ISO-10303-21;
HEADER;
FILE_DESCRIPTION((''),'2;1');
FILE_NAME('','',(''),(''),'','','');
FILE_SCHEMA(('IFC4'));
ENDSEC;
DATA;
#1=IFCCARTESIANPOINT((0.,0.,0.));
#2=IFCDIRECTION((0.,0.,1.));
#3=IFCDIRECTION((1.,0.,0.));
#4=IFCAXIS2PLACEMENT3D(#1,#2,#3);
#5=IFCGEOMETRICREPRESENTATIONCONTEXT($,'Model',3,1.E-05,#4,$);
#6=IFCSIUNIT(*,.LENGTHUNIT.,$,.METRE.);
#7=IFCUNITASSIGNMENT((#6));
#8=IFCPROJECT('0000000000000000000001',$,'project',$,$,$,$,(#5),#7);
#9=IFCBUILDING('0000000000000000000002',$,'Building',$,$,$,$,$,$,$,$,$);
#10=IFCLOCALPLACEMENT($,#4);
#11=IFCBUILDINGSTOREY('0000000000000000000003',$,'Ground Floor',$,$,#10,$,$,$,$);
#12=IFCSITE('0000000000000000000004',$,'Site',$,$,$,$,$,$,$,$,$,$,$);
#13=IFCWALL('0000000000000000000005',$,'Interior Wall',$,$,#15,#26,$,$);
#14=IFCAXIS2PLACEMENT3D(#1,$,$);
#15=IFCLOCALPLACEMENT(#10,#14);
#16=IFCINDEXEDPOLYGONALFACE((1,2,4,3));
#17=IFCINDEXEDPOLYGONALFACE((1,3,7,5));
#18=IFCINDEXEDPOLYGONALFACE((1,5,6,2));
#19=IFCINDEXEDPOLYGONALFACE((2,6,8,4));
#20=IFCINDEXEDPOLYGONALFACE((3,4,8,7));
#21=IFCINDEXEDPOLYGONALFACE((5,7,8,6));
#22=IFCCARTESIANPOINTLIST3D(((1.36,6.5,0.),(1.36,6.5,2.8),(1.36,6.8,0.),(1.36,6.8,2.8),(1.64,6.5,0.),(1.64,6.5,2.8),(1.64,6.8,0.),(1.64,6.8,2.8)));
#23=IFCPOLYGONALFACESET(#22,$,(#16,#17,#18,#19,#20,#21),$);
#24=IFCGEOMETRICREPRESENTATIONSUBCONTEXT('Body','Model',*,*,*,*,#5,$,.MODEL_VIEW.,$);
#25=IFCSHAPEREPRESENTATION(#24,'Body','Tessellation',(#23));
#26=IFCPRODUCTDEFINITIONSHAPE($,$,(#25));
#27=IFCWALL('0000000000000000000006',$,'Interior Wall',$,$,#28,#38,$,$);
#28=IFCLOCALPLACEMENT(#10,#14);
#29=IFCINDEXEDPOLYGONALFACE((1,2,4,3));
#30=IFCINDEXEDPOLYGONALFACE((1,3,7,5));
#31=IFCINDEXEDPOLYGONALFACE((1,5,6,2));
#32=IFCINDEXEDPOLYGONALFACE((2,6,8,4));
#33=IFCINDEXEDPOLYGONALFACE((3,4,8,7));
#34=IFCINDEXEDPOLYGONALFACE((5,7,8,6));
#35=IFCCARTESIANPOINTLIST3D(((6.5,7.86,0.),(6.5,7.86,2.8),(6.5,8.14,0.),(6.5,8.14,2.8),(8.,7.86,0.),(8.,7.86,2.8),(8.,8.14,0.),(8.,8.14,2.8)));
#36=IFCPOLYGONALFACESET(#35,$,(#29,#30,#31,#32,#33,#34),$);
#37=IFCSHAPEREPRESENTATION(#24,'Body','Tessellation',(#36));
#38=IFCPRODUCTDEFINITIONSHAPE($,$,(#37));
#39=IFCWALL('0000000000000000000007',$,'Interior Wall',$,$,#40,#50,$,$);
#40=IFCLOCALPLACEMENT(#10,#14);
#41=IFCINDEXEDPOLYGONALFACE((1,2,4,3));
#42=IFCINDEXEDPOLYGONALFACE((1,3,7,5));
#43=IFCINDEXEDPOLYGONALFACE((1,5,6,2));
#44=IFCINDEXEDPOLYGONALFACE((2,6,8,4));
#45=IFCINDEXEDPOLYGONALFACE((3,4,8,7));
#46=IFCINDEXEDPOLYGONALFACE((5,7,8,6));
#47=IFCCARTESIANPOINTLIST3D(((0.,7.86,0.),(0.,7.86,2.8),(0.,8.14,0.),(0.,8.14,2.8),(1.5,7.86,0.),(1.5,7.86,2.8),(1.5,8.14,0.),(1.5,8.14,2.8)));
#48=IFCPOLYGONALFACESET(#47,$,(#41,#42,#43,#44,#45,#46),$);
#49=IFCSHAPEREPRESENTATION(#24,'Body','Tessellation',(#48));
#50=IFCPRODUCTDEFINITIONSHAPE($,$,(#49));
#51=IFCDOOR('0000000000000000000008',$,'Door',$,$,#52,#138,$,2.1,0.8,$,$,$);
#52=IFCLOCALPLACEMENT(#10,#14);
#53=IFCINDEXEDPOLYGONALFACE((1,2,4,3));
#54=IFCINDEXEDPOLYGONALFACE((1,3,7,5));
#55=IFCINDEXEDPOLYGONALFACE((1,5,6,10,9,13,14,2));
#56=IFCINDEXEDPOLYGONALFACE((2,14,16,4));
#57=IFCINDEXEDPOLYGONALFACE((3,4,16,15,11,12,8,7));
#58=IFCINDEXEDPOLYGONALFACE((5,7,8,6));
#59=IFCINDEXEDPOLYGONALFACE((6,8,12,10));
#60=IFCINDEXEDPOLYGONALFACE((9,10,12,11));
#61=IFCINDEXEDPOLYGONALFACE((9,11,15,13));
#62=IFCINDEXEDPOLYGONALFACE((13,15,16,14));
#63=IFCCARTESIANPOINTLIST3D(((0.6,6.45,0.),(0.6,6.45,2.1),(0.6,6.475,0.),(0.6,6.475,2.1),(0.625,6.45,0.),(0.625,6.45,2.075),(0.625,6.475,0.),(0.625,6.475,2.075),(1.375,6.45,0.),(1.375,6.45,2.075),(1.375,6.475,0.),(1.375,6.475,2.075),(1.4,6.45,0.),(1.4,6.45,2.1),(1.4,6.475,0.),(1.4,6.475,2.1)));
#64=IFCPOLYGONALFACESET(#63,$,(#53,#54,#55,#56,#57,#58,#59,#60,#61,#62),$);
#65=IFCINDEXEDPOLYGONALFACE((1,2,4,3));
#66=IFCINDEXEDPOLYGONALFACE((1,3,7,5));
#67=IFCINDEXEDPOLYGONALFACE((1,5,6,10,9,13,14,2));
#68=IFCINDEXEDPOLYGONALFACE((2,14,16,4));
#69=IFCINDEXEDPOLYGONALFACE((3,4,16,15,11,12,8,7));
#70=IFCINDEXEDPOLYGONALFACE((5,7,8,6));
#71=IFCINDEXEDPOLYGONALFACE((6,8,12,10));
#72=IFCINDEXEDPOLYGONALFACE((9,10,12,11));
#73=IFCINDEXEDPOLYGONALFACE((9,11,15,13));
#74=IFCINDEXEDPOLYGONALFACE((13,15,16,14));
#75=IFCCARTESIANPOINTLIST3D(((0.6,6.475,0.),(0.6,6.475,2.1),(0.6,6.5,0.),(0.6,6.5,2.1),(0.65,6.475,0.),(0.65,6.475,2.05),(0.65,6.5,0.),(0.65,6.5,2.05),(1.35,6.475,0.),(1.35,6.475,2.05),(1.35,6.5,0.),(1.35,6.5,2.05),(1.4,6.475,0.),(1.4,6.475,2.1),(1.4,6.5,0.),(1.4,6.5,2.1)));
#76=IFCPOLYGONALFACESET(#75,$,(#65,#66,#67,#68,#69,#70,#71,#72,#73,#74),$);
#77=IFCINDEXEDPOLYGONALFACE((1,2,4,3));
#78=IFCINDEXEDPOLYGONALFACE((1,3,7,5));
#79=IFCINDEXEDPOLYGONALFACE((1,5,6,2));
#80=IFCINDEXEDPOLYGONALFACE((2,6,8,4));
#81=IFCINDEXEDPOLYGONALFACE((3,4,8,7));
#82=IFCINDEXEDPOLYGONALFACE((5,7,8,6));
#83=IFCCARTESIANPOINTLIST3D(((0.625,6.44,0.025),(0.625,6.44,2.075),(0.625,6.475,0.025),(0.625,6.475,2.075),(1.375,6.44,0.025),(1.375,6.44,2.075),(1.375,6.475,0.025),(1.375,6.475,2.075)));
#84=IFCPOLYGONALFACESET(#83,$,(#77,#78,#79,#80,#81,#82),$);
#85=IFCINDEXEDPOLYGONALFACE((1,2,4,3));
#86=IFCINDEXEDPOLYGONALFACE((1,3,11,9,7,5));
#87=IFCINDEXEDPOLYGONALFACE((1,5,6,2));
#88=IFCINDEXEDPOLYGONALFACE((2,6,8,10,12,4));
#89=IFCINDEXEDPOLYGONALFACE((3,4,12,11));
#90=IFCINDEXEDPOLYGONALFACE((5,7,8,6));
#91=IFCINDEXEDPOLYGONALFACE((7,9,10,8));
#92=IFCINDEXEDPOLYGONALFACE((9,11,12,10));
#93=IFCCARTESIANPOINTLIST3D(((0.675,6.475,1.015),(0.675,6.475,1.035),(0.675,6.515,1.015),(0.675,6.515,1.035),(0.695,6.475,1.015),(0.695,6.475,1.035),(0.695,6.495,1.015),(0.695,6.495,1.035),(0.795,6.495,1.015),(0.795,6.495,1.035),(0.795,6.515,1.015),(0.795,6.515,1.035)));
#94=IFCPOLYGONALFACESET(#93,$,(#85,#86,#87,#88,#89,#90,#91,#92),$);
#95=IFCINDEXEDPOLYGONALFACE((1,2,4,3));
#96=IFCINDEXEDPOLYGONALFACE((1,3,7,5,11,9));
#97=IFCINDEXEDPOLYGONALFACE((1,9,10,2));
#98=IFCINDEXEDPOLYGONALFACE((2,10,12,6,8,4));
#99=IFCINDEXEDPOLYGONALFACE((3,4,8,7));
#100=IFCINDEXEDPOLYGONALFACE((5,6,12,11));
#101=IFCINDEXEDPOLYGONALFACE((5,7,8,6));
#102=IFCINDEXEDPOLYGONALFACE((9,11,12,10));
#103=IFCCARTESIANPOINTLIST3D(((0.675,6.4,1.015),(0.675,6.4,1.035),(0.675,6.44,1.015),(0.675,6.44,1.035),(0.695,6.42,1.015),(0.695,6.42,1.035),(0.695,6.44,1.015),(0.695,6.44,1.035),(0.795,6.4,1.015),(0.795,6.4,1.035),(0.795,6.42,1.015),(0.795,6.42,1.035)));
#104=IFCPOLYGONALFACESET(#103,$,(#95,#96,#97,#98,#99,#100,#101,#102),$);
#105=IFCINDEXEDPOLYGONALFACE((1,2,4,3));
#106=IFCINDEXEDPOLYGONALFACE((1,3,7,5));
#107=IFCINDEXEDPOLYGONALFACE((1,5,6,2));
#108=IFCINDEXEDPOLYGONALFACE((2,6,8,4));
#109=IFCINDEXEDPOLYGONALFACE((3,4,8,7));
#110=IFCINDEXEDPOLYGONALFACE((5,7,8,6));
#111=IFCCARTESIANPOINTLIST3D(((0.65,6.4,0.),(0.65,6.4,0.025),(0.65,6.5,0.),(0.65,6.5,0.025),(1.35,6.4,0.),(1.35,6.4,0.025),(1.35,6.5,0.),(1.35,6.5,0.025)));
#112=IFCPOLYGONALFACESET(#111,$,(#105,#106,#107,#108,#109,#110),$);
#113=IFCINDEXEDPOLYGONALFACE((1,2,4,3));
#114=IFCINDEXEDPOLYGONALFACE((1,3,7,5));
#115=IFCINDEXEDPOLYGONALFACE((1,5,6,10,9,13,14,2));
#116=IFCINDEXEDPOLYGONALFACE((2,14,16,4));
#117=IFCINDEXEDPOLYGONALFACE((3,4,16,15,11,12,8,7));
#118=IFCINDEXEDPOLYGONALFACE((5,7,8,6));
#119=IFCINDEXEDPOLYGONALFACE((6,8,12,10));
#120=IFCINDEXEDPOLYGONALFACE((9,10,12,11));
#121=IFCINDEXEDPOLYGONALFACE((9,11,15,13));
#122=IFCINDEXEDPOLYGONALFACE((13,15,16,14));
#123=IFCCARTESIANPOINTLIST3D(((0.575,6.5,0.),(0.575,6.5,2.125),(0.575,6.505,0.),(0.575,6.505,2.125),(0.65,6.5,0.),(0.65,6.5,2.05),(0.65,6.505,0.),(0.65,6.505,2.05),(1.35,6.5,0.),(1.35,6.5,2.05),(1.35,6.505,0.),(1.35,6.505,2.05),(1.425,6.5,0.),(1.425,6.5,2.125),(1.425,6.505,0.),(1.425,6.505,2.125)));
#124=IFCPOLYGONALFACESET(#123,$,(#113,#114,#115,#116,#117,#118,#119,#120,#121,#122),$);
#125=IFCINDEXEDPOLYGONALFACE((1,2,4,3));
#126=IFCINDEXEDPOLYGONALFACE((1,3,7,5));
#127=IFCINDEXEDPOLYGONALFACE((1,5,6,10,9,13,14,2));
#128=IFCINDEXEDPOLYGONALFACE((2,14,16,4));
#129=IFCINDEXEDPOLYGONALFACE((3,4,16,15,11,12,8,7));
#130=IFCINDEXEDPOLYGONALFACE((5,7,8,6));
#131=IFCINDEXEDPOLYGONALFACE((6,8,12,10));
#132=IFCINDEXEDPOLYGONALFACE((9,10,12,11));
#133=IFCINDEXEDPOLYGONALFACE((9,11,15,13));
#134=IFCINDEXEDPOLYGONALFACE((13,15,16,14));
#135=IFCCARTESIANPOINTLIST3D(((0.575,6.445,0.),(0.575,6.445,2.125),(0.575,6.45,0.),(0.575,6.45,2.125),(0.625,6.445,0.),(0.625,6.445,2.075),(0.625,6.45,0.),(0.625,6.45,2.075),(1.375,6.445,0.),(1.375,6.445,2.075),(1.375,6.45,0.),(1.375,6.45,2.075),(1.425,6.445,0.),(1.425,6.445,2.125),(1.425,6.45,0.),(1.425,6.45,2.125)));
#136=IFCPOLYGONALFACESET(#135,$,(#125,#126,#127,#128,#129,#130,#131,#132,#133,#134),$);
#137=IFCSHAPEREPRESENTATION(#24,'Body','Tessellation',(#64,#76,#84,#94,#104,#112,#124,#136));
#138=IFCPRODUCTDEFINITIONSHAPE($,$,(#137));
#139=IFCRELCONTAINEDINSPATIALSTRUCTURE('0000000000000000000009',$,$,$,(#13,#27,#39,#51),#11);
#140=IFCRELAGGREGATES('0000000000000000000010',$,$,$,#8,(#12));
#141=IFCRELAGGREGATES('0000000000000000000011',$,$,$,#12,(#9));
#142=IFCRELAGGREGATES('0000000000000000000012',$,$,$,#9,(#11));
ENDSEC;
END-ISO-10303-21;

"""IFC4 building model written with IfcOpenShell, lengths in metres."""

from ifc_helpers import new_model, si_unit, frame, origin_with_axes, place, context, subcontext, project, spatial, line, indexed_curve, outline, extrude, element, save


model = new_model("IFC4")

# Units and contexts
model_context = context("Model", 3, precision=1e-05, world=origin_with_axes())
body_context = subcontext(model_context, "Body", "Model", "MODEL_VIEW")
ifc_project = project(units=[si_unit("LENGTHUNIT", "METRE")], contexts=[model_context])

# Site, building, storey
site = spatial("IfcSite", under=ifc_project, Name="Site")
building = spatial("IfcBuilding", under=site, Name="Building")
storey_placement = place(None, origin_with_axes())
storey = spatial("IfcBuildingStorey", under=building, at=storey_placement, Name="Ground Floor")

# Walls
for number, where, z_axis, x_axis, name in (
    (1, (1.5, 6.8, 0.0), (0.0, 0.0, 1.0), (0.0, -1.0, 0.0), "Interior Wall"),
):
    element("IfcWall", number, at=place(storey_placement, frame(where, z_axis=z_axis, x_axis=x_axis)), inside=storey, Name=name, context=body_context, shape_type="SweptSolid", body=[
        extrude(outline(indexed_curve([(0.0, 0.0), (0.0, 0.28), (0.3, 0.28), (0.3, 0.0), (0.0, 0.0)], self_intersect=False)), frame((0.0, -0.14, 0.0), z_axis=(0.0, 0.0, 1.0), x_axis=(1.0, 0.0, 0.0)), (0.0, 0.0, 1.0), 2.8),
    ])
for number, where, z_axis, x_axis, name in (
    (2, (8.0, 8.0, 0.0), (0.0, 0.0, 1.0), (-1.0, 0.0, 0.0), "Interior Wall"),
    (3, (1.5, 8.0, 0.0), (0.0, 0.0, 1.0), (-1.0, 0.0, 0.0), "Interior Wall"),
):
    element("IfcWall", number, at=place(storey_placement, frame(where, z_axis=z_axis, x_axis=x_axis)), inside=storey, Name=name, context=body_context, shape_type="SweptSolid", body=[
        extrude(outline(indexed_curve([(0.0, 0.0), (0.0, 0.28), (1.5, 0.28), (1.5, 0.0), (0.0, 0.0)], self_intersect=False)), frame((0.0, -0.14, 0.0), z_axis=(0.0, 0.0, 1.0), x_axis=(1.0, 0.0, 0.0)), (0.0, 0.0, 1.0), 2.8),
    ])

# Door
door_1_placement = place(storey_placement, frame((1.4, 6.5, 0.0), z_axis=(0.0, 0.0, 1.0), x_axis=(-1.0, 0.0, 0.0)))
element("IfcDoor", 4, at=door_1_placement, inside=storey, Name="Door", OverallHeight=2.1, OverallWidth=0.8, context=body_context, shape_type="SweptSolid", body=[
    extrude(outline(indexed_curve([(0.0, 0.0), (0.0, 2.1), (0.8, 2.1), (0.8, 0.0), (0.775, 0.0), (0.775, 2.075), (0.025, 2.075), (0.025, 0.0)], segments=[line(1, 2, 3, 4, 5, 6, 7, 8, 1)])), frame((0.0, 0.025, 0.0), z_axis=(0.0, -1.0, 0.0), x_axis=(1.0, 0.0, 0.0)), (0.0, 0.0, -1.0), 0.025),
    extrude(outline(indexed_curve([(0.0, 0.0), (0.0, 2.1), (0.8, 2.1), (0.8, 0.0), (0.75, 0.0), (0.75, 2.05), (0.05, 2.05), (0.05, 0.0)], segments=[line(1, 2, 3, 4, 5, 6, 7, 8, 1)])), frame((0.0, 0.0, 0.0), z_axis=(0.0, -1.0, 0.0), x_axis=(1.0, 0.0, 0.0)), (0.0, 0.0, -1.0), 0.025),
    extrude(outline(indexed_curve([(0.0, 0.0), (0.75, 0.0), (0.75, 0.035), (0.0, 0.035)], segments=[line(1, 2, 3, 4, 1)])), frame((0.025, 0.025, 0.025), z_axis=(0.0, 0.0, 1.0), x_axis=(1.0, 0.0, 0.0)), (0.0, 0.0, 1.0), 2.05),
    extrude(outline(indexed_curve([(0.0, 0.0), (0.0, -0.04), (-0.12, -0.04), (-0.12, -0.02), (-0.02, -0.02), (-0.02, 0.0)], segments=[line(1, 2, 3, 4, 5, 6, 1)])), frame((0.725, 0.025, 1.015), z_axis=(0.0, 0.0, 1.0), x_axis=(1.0, 0.0, 0.0)), (0.0, 0.0, 1.0), 0.02),
    extrude(outline(indexed_curve([(0.0, 0.0), (0.0, 0.04), (-0.12, 0.04), (-0.12, 0.02), (-0.02, 0.02), (-0.02, 0.0)], segments=[line(1, 2, 3, 4, 5, 6, 1)])), frame((0.725, 0.06, 1.015), z_axis=(0.0, 0.0, 1.0), x_axis=(1.0, 0.0, 0.0)), (0.0, 0.0, 1.0), 0.02),
    extrude(outline(indexed_curve([(0.0, 0.0), (0.7, 0.0), (0.7, 0.1), (0.0, 0.1)], segments=[line(1, 2, 3, 4, 1)])), frame((0.05, 0.0, 0.0), z_axis=(0.0, 0.0, 1.0), x_axis=(1.0, 0.0, 0.0)), (0.0, 0.0, 1.0), 0.025),
    extrude(outline(indexed_curve([(0.0, 0.0), (0.0, 2.125), (0.85, 2.125), (0.85, 0.0), (0.775, 0.0), (0.775, 2.05), (0.075, 2.05), (0.075, 0.0)], segments=[line(1, 2, 3, 4, 5, 6, 7, 8, 1)])), frame((-0.025, -0.005, 0.0), z_axis=(0.0, -1.0, 0.0), x_axis=(1.0, 0.0, 0.0)), (0.0, 0.0, -1.0), 0.005),
    extrude(outline(indexed_curve([(0.0, 0.0), (0.0, 2.125), (0.85, 2.125), (0.85, 0.0), (0.8, 0.0), (0.8, 2.075), (0.05, 2.075), (0.05, 0.0)], segments=[line(1, 2, 3, 4, 5, 6, 7, 8, 1)])), frame((-0.025, 0.05, 0.0), z_axis=(0.0, -1.0, 0.0), x_axis=(1.0, 0.0, 0.0)), (0.0, 0.0, -1.0), 0.005),
])

save(model, "model.ifc")
